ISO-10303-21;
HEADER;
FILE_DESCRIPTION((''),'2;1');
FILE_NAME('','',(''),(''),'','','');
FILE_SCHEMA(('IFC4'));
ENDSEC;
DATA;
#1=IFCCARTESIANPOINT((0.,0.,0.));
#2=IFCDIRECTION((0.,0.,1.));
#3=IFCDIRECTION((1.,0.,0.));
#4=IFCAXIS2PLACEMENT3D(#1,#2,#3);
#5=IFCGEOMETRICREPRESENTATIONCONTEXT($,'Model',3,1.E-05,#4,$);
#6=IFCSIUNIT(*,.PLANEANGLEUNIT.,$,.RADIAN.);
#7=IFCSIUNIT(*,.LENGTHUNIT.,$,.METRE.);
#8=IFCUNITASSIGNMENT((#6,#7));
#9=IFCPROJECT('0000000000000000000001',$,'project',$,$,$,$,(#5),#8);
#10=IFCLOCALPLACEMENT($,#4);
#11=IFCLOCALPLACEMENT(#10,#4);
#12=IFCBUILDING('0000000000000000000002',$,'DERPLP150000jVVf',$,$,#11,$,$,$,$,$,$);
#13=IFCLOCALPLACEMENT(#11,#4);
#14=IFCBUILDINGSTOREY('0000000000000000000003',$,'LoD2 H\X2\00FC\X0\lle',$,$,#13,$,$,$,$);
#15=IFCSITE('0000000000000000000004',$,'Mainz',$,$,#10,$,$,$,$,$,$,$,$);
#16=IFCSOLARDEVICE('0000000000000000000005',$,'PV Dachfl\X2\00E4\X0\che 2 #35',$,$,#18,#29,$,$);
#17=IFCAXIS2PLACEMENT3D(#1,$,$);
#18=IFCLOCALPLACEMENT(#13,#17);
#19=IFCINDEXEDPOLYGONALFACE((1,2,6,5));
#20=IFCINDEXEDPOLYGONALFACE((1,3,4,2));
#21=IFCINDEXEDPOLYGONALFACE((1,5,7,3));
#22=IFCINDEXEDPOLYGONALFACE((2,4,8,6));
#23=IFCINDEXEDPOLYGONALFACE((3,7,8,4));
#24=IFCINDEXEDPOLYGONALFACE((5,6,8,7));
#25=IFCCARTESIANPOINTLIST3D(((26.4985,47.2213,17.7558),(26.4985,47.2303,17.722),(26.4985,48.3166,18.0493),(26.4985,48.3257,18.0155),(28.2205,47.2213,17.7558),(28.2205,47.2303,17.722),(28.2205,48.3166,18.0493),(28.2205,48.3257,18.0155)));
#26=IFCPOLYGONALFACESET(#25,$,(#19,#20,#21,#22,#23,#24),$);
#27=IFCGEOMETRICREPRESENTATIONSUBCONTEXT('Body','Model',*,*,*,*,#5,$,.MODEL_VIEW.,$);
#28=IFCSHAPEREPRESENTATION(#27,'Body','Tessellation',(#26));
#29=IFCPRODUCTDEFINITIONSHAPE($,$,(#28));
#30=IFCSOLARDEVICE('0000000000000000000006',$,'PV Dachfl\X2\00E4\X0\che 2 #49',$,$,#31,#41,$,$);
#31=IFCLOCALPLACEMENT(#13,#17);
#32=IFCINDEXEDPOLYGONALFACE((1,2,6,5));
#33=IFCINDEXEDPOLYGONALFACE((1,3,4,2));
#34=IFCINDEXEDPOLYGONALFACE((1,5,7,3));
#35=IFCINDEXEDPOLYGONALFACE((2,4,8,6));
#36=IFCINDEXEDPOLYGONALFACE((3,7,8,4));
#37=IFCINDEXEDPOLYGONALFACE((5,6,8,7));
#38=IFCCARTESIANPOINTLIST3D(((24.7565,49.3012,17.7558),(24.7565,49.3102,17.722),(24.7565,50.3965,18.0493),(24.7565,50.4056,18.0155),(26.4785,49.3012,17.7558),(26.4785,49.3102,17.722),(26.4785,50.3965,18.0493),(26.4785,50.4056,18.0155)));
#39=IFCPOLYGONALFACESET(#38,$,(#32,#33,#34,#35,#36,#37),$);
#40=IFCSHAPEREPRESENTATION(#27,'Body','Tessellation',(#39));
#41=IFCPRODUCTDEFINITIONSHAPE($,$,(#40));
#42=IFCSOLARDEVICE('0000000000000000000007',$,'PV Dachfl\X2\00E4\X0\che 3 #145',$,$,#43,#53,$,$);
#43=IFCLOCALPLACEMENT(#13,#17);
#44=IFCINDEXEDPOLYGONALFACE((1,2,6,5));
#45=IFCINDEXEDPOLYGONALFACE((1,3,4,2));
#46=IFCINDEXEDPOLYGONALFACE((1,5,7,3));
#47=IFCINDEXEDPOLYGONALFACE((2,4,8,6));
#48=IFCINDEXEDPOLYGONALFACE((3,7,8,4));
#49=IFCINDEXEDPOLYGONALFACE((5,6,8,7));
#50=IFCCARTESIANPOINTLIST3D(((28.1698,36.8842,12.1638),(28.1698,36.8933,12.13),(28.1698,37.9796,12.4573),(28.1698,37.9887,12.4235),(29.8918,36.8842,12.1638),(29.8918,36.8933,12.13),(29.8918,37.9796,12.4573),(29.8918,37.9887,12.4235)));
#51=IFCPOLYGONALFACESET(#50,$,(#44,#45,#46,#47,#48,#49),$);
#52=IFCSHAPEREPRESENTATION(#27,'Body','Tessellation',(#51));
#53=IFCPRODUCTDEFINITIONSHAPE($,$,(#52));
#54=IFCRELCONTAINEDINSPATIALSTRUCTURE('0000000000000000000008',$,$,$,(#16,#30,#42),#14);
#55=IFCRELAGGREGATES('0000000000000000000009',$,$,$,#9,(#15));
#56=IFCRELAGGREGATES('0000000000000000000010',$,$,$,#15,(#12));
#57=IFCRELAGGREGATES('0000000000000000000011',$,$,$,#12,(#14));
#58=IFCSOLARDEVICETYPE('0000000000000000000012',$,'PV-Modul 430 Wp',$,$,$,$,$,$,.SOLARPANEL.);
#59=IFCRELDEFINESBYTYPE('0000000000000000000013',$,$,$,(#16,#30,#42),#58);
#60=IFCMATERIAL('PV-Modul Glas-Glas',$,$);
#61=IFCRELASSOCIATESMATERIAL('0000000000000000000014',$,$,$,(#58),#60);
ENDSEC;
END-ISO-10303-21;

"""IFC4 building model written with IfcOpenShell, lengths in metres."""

from ifc_helpers import new_model, si_unit, frame, frame_2d, origin, origin_with_axes, place, context, subcontext, project, spatial, rectangle, extrude, source, transform, mapped, material, type_object, type_shapes, element, save


model = new_model("IFC4")

# Units and contexts
model_context = context("Model", 3, precision=1e-05, world=origin_with_axes())
body_context = subcontext(model_context, "Body", "Model", "MODEL_VIEW")
ifc_project = project(units=[si_unit("PLANEANGLEUNIT", "RADIAN"), si_unit("LENGTHUNIT", "METRE")], contexts=[model_context])

# Site, building, storey
site_placement = place(None, origin_with_axes())
site = spatial("IfcSite", under=ifc_project, at=site_placement, Name="Mainz")
building_placement = place(site_placement, origin_with_axes())
building = spatial("IfcBuilding", under=site, at=building_placement, Name="DERPLP150000jVVf")
storey_placement = place(building_placement, origin_with_axes())
storey = spatial("IfcBuildingStorey", under=building, at=storey_placement, Name="LoD2 Hülle")

# Solar devices
ifc_material = material(Name="PV-Modul Glas-Glas")
solar_device_type = type_object("IfcSolarDeviceType", Name="PV-Modul 430 Wp", PredefinedType="SOLARPANEL", material=ifc_material)
shared_shape = source(origin_with_axes(), body_context, "Body", "SweptSolid", [
    extrude(rectangle(XDim=1.722, YDim=1.134, at=frame_2d((0.861, 0.567))), origin(), (0.0, 0.0, 1.0), 0.035),
])
type_shapes(solar_device_type, [shared_shape])
for number, where, z_axis, x_axis, name in (
    (1, (26.4985, 47.2303, 17.722), (0.0, -0.258819, 0.965926), (1.0, 0.0, 0.0), "PV Dachfläche 2 #35"),
    (2, (24.7565, 49.3102, 17.722), (0.0, -0.258819, 0.965926), (1.0, 0.0, 0.0), "PV Dachfläche 2 #49"),
    (3, (28.1698, 36.8933, 12.13), (0.0, -0.258819, 0.965926), (1.0, 0.0, 0.0), "PV Dachfläche 3 #145"),
):
    element("IfcSolarDevice", number, at=place(storey_placement, frame(where, z_axis=z_axis, x_axis=x_axis)), inside=storey, type_object=solar_device_type, Name=name, context=body_context, shape_type="MappedRepresentation", body=[
        mapped(shared_shape, transform((0.0, 0.0, 0.0), x_axis=(1.0, 0.0, 0.0), y_axis=(0.0, 1.0, 0.0), z_axis=(0.0, 0.0, 1.0), scale=1.0)),
    ])

save(model, "model.ifc")
